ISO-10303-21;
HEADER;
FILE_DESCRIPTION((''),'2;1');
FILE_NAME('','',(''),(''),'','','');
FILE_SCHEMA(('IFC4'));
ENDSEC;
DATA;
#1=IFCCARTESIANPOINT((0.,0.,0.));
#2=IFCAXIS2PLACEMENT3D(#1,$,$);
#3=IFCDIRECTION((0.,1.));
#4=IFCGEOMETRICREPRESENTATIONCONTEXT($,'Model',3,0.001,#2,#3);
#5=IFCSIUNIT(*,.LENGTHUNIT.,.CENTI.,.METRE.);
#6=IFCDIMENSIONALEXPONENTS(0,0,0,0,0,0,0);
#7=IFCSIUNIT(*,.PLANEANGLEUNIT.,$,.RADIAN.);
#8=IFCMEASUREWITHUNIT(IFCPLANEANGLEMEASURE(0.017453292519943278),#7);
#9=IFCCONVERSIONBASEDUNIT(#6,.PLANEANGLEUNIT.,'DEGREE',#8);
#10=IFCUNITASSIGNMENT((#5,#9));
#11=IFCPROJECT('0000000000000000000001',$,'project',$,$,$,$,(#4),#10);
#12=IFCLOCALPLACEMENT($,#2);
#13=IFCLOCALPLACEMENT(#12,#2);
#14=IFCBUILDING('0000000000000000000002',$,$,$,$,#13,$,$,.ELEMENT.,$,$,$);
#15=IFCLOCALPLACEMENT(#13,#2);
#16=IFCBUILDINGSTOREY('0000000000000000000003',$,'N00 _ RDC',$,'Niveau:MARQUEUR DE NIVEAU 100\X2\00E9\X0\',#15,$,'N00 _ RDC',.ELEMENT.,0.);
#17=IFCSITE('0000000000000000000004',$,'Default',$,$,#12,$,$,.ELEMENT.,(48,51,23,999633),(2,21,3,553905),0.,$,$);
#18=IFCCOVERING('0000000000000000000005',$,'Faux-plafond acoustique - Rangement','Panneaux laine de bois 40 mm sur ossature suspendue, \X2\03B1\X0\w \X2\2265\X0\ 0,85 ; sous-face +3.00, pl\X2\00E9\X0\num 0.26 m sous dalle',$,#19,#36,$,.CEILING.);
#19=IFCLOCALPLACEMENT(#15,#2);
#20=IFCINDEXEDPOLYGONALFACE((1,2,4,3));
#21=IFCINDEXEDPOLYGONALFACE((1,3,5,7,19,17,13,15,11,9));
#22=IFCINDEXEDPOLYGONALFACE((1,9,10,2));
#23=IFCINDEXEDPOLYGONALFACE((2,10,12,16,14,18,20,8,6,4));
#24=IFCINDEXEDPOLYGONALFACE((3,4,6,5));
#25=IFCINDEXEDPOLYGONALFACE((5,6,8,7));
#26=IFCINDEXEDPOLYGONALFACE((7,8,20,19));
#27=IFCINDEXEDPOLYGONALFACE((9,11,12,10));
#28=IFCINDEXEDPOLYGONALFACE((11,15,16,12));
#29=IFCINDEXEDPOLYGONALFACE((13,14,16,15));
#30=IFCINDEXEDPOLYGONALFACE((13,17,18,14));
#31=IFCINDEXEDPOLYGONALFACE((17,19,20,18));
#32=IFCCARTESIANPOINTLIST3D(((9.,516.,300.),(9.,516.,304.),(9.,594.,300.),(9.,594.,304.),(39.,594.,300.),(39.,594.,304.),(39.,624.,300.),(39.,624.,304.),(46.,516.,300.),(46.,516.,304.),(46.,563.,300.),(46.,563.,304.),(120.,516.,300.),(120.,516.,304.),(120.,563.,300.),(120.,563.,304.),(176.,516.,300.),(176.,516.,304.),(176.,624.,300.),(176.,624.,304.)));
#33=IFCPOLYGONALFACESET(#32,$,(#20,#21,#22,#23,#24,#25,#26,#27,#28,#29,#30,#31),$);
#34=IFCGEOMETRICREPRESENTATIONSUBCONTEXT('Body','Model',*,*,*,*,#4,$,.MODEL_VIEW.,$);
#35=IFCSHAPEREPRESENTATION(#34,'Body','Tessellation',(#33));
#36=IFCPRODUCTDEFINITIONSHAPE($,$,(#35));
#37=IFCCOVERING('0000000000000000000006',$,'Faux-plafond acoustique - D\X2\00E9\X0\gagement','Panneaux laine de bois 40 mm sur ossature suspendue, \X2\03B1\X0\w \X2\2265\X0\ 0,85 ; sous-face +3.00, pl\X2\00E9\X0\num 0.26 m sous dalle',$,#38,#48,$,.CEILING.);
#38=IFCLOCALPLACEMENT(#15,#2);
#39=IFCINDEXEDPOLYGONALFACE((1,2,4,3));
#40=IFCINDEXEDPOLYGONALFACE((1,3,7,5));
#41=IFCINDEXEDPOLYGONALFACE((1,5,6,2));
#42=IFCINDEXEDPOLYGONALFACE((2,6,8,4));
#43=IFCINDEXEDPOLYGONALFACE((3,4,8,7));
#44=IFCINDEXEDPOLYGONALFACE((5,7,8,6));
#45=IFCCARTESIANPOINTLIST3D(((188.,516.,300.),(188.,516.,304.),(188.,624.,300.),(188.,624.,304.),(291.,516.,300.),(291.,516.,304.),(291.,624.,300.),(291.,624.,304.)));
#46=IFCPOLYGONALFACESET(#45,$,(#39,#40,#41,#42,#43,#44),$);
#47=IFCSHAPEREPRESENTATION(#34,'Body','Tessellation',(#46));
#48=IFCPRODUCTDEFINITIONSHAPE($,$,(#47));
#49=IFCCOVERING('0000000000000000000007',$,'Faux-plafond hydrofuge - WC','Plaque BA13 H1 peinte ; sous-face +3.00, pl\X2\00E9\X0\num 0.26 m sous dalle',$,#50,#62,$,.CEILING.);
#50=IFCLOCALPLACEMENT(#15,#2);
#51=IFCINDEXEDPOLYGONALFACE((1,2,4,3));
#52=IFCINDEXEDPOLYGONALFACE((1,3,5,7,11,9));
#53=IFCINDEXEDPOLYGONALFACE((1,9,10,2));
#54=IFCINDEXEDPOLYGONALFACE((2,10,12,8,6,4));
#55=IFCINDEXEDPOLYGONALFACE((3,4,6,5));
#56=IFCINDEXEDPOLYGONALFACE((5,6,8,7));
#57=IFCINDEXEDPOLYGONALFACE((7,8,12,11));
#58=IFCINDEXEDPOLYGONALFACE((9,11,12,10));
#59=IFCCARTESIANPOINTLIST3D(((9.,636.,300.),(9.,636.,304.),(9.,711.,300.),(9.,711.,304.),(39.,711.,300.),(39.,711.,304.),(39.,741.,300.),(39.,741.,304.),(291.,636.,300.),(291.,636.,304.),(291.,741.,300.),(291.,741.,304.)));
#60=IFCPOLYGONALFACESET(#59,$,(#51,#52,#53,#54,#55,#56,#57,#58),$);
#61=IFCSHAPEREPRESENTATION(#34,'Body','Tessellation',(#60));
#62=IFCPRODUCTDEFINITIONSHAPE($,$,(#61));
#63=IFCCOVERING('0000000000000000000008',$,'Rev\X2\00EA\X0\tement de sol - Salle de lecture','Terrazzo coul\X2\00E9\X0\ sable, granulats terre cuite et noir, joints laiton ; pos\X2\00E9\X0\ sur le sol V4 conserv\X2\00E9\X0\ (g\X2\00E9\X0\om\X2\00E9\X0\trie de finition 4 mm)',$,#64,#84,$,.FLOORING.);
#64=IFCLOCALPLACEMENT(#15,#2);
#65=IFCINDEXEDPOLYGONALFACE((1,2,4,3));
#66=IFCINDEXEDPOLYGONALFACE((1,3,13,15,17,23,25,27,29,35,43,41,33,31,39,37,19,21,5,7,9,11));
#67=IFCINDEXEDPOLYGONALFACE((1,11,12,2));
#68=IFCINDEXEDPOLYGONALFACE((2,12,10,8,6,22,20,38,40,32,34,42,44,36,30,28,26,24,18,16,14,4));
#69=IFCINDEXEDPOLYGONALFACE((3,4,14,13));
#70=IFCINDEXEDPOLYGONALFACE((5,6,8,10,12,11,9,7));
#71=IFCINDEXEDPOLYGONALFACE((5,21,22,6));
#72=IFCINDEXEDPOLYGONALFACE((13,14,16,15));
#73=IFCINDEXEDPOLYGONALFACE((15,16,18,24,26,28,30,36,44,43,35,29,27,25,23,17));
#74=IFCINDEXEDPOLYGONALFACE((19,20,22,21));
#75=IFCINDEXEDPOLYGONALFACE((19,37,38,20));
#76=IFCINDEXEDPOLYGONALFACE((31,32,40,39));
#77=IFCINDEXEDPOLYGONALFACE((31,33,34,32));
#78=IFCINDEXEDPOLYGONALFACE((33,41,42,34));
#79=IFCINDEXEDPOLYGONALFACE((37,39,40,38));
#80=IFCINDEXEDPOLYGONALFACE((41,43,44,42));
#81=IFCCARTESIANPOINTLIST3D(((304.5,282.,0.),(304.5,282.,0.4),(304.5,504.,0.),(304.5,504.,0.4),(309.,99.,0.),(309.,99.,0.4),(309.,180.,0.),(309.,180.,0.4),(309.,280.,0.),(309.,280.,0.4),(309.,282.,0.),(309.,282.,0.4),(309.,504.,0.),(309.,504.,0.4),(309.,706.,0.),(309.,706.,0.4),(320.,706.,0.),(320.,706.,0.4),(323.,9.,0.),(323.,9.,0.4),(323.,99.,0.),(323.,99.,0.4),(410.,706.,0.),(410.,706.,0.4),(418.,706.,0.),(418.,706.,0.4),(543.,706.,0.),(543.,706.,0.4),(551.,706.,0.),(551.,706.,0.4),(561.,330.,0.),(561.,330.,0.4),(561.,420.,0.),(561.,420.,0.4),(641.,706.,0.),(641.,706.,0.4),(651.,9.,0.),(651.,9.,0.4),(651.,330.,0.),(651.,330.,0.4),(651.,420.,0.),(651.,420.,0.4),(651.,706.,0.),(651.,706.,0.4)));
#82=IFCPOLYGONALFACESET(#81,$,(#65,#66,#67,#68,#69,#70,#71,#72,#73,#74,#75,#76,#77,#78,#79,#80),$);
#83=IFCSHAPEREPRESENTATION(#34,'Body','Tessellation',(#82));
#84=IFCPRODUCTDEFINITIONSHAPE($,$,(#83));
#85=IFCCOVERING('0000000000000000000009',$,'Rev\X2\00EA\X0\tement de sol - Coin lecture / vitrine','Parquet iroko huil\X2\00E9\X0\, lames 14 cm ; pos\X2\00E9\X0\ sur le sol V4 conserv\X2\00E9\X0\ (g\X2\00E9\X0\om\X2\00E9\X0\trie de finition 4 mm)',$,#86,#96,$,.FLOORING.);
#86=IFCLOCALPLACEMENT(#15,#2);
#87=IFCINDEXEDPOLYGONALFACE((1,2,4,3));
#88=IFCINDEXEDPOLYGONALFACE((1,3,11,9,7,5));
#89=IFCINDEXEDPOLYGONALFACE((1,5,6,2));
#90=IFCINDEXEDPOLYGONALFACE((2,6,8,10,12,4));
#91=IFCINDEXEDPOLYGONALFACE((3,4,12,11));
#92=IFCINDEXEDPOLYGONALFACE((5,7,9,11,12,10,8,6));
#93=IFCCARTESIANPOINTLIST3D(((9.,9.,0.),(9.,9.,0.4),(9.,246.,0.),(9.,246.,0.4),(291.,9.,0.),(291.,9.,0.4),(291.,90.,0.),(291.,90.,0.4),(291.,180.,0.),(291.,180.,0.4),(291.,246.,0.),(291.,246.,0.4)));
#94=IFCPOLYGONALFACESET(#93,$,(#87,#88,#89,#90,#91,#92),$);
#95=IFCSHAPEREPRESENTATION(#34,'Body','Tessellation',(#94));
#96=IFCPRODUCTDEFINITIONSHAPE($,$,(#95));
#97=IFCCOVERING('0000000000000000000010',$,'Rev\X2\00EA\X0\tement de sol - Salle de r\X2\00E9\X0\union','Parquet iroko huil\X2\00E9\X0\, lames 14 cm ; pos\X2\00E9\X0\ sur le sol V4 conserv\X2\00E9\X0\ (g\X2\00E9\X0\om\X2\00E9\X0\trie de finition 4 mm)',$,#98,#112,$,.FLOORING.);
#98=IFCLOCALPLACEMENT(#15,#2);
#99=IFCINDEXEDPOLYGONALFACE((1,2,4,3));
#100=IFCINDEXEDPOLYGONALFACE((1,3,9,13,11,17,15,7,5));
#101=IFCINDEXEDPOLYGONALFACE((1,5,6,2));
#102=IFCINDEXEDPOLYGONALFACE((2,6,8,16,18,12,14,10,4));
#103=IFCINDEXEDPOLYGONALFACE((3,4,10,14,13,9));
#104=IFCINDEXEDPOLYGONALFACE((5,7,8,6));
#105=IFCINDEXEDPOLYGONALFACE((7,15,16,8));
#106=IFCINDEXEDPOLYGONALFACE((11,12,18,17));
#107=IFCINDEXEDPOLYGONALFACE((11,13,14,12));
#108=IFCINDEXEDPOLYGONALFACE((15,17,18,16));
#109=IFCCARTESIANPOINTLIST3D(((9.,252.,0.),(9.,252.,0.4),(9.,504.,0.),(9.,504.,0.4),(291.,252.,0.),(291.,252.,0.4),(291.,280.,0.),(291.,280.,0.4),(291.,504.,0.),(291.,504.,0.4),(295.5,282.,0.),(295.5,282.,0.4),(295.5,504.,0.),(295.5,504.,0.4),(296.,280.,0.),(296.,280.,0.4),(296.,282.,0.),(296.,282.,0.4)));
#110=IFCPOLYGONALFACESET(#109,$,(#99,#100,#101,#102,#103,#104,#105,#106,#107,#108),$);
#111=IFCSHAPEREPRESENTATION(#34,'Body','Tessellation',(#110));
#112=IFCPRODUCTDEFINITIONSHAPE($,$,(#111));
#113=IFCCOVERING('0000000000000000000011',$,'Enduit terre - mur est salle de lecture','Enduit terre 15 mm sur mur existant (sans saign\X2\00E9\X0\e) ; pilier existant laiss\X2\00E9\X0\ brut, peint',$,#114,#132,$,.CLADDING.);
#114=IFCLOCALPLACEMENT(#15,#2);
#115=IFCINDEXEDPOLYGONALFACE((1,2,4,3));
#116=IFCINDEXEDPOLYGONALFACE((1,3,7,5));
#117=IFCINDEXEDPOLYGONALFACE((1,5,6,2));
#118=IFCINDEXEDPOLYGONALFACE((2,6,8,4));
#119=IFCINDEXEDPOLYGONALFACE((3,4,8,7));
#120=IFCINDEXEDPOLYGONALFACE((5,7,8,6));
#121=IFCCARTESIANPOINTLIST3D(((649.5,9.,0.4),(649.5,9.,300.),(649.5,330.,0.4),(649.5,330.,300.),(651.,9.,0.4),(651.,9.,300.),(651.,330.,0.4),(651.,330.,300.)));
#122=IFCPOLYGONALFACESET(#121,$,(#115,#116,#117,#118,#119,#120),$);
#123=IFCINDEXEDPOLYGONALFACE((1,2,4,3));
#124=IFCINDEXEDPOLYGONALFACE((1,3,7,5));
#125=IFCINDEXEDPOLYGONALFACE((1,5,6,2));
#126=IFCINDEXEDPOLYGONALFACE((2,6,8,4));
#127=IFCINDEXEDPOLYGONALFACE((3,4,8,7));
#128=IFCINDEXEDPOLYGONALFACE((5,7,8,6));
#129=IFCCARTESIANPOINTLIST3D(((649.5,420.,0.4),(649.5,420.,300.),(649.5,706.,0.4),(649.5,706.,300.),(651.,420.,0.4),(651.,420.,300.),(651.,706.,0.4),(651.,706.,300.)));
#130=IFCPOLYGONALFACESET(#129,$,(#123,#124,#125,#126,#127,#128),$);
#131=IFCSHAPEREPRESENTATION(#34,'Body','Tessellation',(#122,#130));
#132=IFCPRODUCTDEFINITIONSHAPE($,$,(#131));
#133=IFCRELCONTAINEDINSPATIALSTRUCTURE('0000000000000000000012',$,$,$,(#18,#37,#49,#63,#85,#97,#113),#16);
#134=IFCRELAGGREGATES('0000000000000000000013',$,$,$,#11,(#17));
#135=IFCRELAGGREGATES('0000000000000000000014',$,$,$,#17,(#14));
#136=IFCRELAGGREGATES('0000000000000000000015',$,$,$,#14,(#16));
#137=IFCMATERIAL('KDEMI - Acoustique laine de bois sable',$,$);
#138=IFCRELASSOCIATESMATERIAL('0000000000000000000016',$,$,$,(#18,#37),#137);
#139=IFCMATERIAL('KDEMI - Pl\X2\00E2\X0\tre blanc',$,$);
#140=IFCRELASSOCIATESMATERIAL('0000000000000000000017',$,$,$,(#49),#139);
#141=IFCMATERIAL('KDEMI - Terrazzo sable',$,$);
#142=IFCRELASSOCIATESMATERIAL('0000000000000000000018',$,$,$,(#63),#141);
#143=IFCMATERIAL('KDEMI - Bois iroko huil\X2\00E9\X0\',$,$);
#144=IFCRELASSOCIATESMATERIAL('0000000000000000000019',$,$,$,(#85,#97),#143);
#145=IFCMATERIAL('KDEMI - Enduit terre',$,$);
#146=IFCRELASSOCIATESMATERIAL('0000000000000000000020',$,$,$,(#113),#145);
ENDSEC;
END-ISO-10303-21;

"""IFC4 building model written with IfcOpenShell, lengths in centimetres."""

from ifc_helpers import new_model, entity, si_unit, converted_unit, direction, frame, frame_2d, origin, origin_with_axes, place, context, subcontext, project, spatial, polyline, rectangle, outline, extrude, material, element, save


model = new_model("IFC4")

# Units and contexts
model_context = context("Model", 3, precision=0.001, world=origin(), true_north=direction((0.0, 1.0)))
body_context = subcontext(model_context, "Body", "Model", "MODEL_VIEW")
ifc_project = project(units=[si_unit("LENGTHUNIT", "METRE", prefix="CENTI"), converted_unit("PLANEANGLEUNIT", "DEGREE", entity("IfcPlaneAngleMeasure", 0.017453292519943278), si_unit("PLANEANGLEUNIT", "RADIAN"), dimensions=[0, 0, 0, 0, 0, 0, 0])], contexts=[model_context])

# Site, building, storey
site_placement = place(None, origin())
site = spatial("IfcSite", under=ifc_project, at=site_placement, Name="Default", CompositionType="ELEMENT", RefLatitude=(48, 51, 23, 999633), RefLongitude=(2, 21, 3, 553905), RefElevation=0.0)
building_placement = place(site_placement, origin())
building = spatial("IfcBuilding", under=site, at=building_placement, CompositionType="ELEMENT")
storey_placement = place(building_placement, origin())
storey = spatial("IfcBuildingStorey", under=building, at=storey_placement, Name="N00 _ RDC", ObjectType="Niveau:MARQUEUR DE NIVEAU 100é", LongName="N00 _ RDC", CompositionType="ELEMENT", Elevation=0.0)

# Shared definitions
ifc_material_1 = material(Name="KDEMI - Plâtre blanc")

# Shared definitions
ifc_material_2 = material(Name="KDEMI - Bois iroko huilé")

# Coverings
ifc_material_3 = material(Name="KDEMI - Acoustique laine de bois sable")
covering_1_placement = place(storey_placement, origin_with_axes())
element("IfcCovering", 1, at=covering_1_placement, inside=storey, material=ifc_material_3, Name="Faux-plafond acoustique - Rangement", Description="Panneaux laine de bois 40 mm sur ossature suspendue, αw ≥ 0,85 ; sous-face +3.00, plénum 0.26 m sous dalle", PredefinedType="CEILING", context=body_context, shape_type="SweptSolid", body=[
    extrude(outline(polyline([(120.0, 563.0), (46.0, 563.0), (46.0, 516.0), (9.0, 516.0), (9.0, 594.0), (39.0, 594.0), (39.0, 624.0), (176.0, 624.0), (176.0, 516.0), (120.0, 516.0), (120.0, 563.0)])), frame((0.0, 0.0, 300.0)), (0.0, 0.0, 1.0), 4.0),
])
covering_2_placement = place(storey_placement, origin_with_axes())
element("IfcCovering", 2, at=covering_2_placement, inside=storey, material=ifc_material_3, Name="Faux-plafond acoustique - Dégagement", Description="Panneaux laine de bois 40 mm sur ossature suspendue, αw ≥ 0,85 ; sous-face +3.00, plénum 0.26 m sous dalle", PredefinedType="CEILING", context=body_context, shape_type="SweptSolid", body=[
    extrude(outline(polyline([(291.0, 516.0), (188.0, 516.0), (188.0, 624.0), (291.0, 624.0), (291.0, 516.0)])), frame((0.0, 0.0, 300.0)), (0.0, 0.0, 1.0), 4.0),
])
covering_3_placement = place(storey_placement, origin_with_axes())
element("IfcCovering", 3, at=covering_3_placement, inside=storey, material=ifc_material_1, Name="Faux-plafond hydrofuge - WC", Description="Plaque BA13 H1 peinte ; sous-face +3.00, plénum 0.26 m sous dalle", PredefinedType="CEILING", context=body_context, shape_type="SweptSolid", body=[
    extrude(outline(polyline([(9.0, 636.0), (9.0, 711.0), (39.0, 711.0), (39.0, 741.0), (291.0, 741.0), (291.0, 636.0), (9.0, 636.0)])), frame((0.0, 0.0, 300.0)), (0.0, 0.0, 1.0), 4.0),
])
ifc_material_4 = material(Name="KDEMI - Terrazzo sable")
covering_4_placement = place(storey_placement, origin_with_axes())
element("IfcCovering", 4, at=covering_4_placement, inside=storey, material=ifc_material_4, Name="Revêtement de sol - Salle de lecture", Description="Terrazzo coulé sable, granulats terre cuite et noir, joints laiton ; posé sur le sol V4 conservé (géométrie de finition 4 mm)", PredefinedType="FLOORING", context=body_context, shape_type="SweptSolid", body=[
    extrude(outline(polyline([(418.0, 706.0), (543.0, 706.0), (551.0, 706.0), (641.0, 706.0), (651.0, 706.0), (651.0, 420.0), (561.0, 420.0), (561.0, 330.0), (651.0, 330.0), (651.0, 9.0), (651.0, 9.0), (651.0, 9.0), (323.0, 9.0), (323.0, 99.0), (309.0, 99.0), (309.0, 180.0), (309.0, 180.0), (309.0, 280.0), (309.0, 280.0), (309.0, 282.0), (304.0, 282.0), (304.0, 282.0), (304.5, 282.0), (304.5, 504.0), (309.0, 504.0), (309.0, 504.0), (309.0, 706.0), (320.0, 706.0), (410.0, 706.0), (418.0, 706.0)])), origin(), (0.0, 0.0, 1.0), 0.4),
])
covering_5_placement = place(storey_placement, origin_with_axes())
element("IfcCovering", 5, at=covering_5_placement, inside=storey, material=ifc_material_2, Name="Revêtement de sol - Coin lecture / vitrine", Description="Parquet iroko huilé, lames 14 cm ; posé sur le sol V4 conservé (géométrie de finition 4 mm)", PredefinedType="FLOORING", context=body_context, shape_type="SweptSolid", body=[
    extrude(outline(polyline([(291.0, 90.0), (291.0, 90.0), (291.0, 9.0), (9.0, 9.0), (9.0, 246.0), (291.0, 246.0), (291.0, 180.0), (291.0, 180.0), (291.0, 90.0)])), origin(), (0.0, 0.0, 1.0), 0.4),
])
covering_6_placement = place(storey_placement, origin_with_axes())
element("IfcCovering", 6, at=covering_6_placement, inside=storey, material=ifc_material_2, Name="Revêtement de sol - Salle de réunion", Description="Parquet iroko huilé, lames 14 cm ; posé sur le sol V4 conservé (géométrie de finition 4 mm)", PredefinedType="FLOORING", context=body_context, shape_type="SweptSolid", body=[
    extrude(outline(polyline([(296.0, 280.0), (291.0, 280.0), (291.0, 252.0), (9.0, 252.0), (9.0, 504.0), (291.0, 504.0), (295.5, 504.0), (295.5, 282.0), (296.0, 282.0), (296.0, 280.0)])), origin(), (0.0, 0.0, 1.0), 0.4),
])
ifc_material_5 = material(Name="KDEMI - Enduit terre")
covering_7_placement = place(storey_placement, origin_with_axes())
element("IfcCovering", 7, at=covering_7_placement, inside=storey, material=ifc_material_5, Name="Enduit terre - mur est salle de lecture", Description="Enduit terre 15 mm sur mur existant (sans saignée) ; pilier existant laissé brut, peint", PredefinedType="CLADDING", context=body_context, shape_type="SweptSolid", body=[
    extrude(rectangle(XDim=1.5, YDim=321.0, at=frame_2d((650.25, 169.5))), frame((0.0, 0.0, 0.4)), (0.0, 0.0, 1.0), 299.6),
    extrude(rectangle(XDim=1.5, YDim=286.0, at=frame_2d((650.25, 563.0))), frame((0.0, 0.0, 0.4)), (0.0, 0.0, 1.0), 299.6),
])

save(model, "model.ifc")
